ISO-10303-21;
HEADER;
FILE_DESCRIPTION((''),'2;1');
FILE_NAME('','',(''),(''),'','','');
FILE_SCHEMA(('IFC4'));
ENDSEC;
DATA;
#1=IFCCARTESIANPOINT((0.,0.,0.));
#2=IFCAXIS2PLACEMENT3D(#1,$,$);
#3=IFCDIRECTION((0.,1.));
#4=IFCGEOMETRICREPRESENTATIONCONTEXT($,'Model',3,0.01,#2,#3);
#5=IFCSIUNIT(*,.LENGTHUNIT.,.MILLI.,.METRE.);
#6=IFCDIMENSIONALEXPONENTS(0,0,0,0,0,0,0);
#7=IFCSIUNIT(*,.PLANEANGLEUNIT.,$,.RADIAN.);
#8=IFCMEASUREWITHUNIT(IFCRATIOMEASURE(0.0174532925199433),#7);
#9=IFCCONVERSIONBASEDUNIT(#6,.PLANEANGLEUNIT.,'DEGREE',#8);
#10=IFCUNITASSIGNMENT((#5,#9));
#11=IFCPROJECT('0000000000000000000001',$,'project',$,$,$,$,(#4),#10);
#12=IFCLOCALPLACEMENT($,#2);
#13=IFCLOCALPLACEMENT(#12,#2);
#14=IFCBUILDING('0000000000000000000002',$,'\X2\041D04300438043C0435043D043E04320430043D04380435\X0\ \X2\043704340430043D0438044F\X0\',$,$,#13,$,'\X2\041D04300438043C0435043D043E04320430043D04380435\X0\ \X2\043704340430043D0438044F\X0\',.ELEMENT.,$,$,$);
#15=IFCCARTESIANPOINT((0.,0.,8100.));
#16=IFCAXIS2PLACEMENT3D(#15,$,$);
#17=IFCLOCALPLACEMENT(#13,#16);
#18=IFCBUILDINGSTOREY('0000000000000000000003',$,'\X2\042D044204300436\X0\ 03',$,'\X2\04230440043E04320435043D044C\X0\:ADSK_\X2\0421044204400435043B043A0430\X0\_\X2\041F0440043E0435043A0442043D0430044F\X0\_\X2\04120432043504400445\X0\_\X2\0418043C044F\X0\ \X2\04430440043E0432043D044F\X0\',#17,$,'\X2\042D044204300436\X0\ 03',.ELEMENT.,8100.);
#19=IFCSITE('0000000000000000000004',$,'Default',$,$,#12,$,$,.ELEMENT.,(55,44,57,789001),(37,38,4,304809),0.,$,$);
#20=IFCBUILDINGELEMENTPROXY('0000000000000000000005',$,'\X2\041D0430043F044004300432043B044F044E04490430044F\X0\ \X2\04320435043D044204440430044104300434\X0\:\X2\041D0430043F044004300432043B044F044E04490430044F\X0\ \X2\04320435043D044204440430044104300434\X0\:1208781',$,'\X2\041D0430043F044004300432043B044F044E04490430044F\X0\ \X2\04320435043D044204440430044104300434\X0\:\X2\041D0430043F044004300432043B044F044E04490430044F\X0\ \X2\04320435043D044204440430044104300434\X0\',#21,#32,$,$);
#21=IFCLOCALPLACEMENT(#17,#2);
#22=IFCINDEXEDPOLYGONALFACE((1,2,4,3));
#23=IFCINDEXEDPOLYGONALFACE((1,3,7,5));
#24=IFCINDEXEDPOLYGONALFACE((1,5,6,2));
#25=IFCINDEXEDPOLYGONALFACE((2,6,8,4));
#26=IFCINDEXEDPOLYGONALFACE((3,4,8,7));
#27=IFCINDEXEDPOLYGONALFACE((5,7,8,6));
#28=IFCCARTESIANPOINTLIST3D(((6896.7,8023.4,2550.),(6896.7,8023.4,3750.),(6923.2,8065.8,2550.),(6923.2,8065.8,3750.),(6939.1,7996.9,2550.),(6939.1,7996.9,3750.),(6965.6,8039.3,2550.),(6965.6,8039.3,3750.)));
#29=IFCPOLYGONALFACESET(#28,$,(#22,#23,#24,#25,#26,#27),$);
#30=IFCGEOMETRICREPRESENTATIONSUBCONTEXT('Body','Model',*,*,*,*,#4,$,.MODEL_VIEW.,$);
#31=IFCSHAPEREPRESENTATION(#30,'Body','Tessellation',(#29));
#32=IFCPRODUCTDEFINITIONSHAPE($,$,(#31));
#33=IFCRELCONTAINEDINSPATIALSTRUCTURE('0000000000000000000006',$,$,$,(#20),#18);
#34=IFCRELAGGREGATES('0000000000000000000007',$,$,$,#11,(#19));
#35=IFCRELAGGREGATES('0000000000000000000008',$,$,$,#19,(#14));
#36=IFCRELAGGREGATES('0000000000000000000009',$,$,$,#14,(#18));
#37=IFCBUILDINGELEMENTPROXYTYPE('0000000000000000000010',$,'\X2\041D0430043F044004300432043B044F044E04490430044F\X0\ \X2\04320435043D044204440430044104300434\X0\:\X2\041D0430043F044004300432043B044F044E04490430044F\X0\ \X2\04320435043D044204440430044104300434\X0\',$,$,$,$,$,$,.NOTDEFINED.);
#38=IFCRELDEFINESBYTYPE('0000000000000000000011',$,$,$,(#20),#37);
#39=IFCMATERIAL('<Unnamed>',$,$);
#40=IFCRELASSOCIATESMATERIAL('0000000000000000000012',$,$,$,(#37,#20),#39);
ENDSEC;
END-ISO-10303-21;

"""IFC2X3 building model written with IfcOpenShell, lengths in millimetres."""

from ifc_helpers import new_model, entity, si_unit, converted_unit, direction, frame, origin, origin_2d_with_axis, place, context, subcontext, project, spatial, rectangle, extrude, source, transform, mapped, material, type_object, type_shapes, element, save


model = new_model("IFC2X3")

# Units and contexts
model_context = context("Model", 3, precision=0.01, world=origin(), true_north=direction((0.0, 1.0)))
body_context = subcontext(model_context, "Body", "Model", "MODEL_VIEW")
ifc_project = project(units=[si_unit("LENGTHUNIT", "METRE", prefix="MILLI"), converted_unit("PLANEANGLEUNIT", "DEGREE", entity("IfcRatioMeasure", 0.0174532925199433), si_unit("PLANEANGLEUNIT", "RADIAN"), dimensions=[0, 0, 0, 0, 0, 0, 0])], contexts=[model_context])

# Site, building, storey
site_placement = place(None, origin())
site = spatial("IfcSite", under=ifc_project, at=site_placement, Name="Default", CompositionType="ELEMENT", RefLatitude=(55, 44, 57, 789001), RefLongitude=(37, 38, 4, 304809), RefElevation=0.0)
building_placement = place(site_placement, origin())
building = spatial("IfcBuilding", under=site, at=building_placement, Name="Наименование здания", LongName="Наименование здания", CompositionType="ELEMENT")
storey_placement = place(building_placement, frame((0.0, 0.0, 8100.0)))
storey = spatial("IfcBuildingStorey", under=building, at=storey_placement, Name="Этаж 03", ObjectType="Уровень:ADSK_Стрелка_Проектная_Вверх_Имя уровня", LongName="Этаж 03", CompositionType="ELEMENT", Elevation=8100.0)

# Building element proxy
ifc_material_1 = material(Name="<Unnamed>")
building_element_proxy_type_1 = type_object("IfcBuildingElementProxyType", Name="Направляющая вентфасад:Направляющая вентфасад", PredefinedType="NOTDEFINED", material=ifc_material_1)
shared_shape_1 = source(origin(), body_context, "Body", "SweptSolid", [
    extrude(rectangle(XDim=50.0, YDim=50.0, at=origin_2d_with_axis()), frame((25.0, -25.0, 0.0), z_axis=(0.0, 0.0, 1.0), x_axis=(-1.0, 0.0, 0.0)), (0.0, 0.0, 1.0), 1200.0),
])
type_shapes(building_element_proxy_type_1, [shared_shape_1])
proxy_1_placement = place(storey_placement, frame((6923.2, 8065.8, 2550.0), z_axis=(0.0, 0.0, 1.0), x_axis=(0.848053, -0.529912, 0.0)))
element("IfcBuildingElementProxy", 1, at=proxy_1_placement, inside=storey, type_object=building_element_proxy_type_1, material=ifc_material_1, Name="Направляющая вентфасад:Направляющая вентфасад:1208781", ObjectType="Направляющая вентфасад:Направляющая вентфасад", context=body_context, shape_type="MappedRepresentation", body=[
    mapped(shared_shape_1, transform((0.0, 0.0, 0.0), scale=1.0)),
])

save(model, "model.ifc")
